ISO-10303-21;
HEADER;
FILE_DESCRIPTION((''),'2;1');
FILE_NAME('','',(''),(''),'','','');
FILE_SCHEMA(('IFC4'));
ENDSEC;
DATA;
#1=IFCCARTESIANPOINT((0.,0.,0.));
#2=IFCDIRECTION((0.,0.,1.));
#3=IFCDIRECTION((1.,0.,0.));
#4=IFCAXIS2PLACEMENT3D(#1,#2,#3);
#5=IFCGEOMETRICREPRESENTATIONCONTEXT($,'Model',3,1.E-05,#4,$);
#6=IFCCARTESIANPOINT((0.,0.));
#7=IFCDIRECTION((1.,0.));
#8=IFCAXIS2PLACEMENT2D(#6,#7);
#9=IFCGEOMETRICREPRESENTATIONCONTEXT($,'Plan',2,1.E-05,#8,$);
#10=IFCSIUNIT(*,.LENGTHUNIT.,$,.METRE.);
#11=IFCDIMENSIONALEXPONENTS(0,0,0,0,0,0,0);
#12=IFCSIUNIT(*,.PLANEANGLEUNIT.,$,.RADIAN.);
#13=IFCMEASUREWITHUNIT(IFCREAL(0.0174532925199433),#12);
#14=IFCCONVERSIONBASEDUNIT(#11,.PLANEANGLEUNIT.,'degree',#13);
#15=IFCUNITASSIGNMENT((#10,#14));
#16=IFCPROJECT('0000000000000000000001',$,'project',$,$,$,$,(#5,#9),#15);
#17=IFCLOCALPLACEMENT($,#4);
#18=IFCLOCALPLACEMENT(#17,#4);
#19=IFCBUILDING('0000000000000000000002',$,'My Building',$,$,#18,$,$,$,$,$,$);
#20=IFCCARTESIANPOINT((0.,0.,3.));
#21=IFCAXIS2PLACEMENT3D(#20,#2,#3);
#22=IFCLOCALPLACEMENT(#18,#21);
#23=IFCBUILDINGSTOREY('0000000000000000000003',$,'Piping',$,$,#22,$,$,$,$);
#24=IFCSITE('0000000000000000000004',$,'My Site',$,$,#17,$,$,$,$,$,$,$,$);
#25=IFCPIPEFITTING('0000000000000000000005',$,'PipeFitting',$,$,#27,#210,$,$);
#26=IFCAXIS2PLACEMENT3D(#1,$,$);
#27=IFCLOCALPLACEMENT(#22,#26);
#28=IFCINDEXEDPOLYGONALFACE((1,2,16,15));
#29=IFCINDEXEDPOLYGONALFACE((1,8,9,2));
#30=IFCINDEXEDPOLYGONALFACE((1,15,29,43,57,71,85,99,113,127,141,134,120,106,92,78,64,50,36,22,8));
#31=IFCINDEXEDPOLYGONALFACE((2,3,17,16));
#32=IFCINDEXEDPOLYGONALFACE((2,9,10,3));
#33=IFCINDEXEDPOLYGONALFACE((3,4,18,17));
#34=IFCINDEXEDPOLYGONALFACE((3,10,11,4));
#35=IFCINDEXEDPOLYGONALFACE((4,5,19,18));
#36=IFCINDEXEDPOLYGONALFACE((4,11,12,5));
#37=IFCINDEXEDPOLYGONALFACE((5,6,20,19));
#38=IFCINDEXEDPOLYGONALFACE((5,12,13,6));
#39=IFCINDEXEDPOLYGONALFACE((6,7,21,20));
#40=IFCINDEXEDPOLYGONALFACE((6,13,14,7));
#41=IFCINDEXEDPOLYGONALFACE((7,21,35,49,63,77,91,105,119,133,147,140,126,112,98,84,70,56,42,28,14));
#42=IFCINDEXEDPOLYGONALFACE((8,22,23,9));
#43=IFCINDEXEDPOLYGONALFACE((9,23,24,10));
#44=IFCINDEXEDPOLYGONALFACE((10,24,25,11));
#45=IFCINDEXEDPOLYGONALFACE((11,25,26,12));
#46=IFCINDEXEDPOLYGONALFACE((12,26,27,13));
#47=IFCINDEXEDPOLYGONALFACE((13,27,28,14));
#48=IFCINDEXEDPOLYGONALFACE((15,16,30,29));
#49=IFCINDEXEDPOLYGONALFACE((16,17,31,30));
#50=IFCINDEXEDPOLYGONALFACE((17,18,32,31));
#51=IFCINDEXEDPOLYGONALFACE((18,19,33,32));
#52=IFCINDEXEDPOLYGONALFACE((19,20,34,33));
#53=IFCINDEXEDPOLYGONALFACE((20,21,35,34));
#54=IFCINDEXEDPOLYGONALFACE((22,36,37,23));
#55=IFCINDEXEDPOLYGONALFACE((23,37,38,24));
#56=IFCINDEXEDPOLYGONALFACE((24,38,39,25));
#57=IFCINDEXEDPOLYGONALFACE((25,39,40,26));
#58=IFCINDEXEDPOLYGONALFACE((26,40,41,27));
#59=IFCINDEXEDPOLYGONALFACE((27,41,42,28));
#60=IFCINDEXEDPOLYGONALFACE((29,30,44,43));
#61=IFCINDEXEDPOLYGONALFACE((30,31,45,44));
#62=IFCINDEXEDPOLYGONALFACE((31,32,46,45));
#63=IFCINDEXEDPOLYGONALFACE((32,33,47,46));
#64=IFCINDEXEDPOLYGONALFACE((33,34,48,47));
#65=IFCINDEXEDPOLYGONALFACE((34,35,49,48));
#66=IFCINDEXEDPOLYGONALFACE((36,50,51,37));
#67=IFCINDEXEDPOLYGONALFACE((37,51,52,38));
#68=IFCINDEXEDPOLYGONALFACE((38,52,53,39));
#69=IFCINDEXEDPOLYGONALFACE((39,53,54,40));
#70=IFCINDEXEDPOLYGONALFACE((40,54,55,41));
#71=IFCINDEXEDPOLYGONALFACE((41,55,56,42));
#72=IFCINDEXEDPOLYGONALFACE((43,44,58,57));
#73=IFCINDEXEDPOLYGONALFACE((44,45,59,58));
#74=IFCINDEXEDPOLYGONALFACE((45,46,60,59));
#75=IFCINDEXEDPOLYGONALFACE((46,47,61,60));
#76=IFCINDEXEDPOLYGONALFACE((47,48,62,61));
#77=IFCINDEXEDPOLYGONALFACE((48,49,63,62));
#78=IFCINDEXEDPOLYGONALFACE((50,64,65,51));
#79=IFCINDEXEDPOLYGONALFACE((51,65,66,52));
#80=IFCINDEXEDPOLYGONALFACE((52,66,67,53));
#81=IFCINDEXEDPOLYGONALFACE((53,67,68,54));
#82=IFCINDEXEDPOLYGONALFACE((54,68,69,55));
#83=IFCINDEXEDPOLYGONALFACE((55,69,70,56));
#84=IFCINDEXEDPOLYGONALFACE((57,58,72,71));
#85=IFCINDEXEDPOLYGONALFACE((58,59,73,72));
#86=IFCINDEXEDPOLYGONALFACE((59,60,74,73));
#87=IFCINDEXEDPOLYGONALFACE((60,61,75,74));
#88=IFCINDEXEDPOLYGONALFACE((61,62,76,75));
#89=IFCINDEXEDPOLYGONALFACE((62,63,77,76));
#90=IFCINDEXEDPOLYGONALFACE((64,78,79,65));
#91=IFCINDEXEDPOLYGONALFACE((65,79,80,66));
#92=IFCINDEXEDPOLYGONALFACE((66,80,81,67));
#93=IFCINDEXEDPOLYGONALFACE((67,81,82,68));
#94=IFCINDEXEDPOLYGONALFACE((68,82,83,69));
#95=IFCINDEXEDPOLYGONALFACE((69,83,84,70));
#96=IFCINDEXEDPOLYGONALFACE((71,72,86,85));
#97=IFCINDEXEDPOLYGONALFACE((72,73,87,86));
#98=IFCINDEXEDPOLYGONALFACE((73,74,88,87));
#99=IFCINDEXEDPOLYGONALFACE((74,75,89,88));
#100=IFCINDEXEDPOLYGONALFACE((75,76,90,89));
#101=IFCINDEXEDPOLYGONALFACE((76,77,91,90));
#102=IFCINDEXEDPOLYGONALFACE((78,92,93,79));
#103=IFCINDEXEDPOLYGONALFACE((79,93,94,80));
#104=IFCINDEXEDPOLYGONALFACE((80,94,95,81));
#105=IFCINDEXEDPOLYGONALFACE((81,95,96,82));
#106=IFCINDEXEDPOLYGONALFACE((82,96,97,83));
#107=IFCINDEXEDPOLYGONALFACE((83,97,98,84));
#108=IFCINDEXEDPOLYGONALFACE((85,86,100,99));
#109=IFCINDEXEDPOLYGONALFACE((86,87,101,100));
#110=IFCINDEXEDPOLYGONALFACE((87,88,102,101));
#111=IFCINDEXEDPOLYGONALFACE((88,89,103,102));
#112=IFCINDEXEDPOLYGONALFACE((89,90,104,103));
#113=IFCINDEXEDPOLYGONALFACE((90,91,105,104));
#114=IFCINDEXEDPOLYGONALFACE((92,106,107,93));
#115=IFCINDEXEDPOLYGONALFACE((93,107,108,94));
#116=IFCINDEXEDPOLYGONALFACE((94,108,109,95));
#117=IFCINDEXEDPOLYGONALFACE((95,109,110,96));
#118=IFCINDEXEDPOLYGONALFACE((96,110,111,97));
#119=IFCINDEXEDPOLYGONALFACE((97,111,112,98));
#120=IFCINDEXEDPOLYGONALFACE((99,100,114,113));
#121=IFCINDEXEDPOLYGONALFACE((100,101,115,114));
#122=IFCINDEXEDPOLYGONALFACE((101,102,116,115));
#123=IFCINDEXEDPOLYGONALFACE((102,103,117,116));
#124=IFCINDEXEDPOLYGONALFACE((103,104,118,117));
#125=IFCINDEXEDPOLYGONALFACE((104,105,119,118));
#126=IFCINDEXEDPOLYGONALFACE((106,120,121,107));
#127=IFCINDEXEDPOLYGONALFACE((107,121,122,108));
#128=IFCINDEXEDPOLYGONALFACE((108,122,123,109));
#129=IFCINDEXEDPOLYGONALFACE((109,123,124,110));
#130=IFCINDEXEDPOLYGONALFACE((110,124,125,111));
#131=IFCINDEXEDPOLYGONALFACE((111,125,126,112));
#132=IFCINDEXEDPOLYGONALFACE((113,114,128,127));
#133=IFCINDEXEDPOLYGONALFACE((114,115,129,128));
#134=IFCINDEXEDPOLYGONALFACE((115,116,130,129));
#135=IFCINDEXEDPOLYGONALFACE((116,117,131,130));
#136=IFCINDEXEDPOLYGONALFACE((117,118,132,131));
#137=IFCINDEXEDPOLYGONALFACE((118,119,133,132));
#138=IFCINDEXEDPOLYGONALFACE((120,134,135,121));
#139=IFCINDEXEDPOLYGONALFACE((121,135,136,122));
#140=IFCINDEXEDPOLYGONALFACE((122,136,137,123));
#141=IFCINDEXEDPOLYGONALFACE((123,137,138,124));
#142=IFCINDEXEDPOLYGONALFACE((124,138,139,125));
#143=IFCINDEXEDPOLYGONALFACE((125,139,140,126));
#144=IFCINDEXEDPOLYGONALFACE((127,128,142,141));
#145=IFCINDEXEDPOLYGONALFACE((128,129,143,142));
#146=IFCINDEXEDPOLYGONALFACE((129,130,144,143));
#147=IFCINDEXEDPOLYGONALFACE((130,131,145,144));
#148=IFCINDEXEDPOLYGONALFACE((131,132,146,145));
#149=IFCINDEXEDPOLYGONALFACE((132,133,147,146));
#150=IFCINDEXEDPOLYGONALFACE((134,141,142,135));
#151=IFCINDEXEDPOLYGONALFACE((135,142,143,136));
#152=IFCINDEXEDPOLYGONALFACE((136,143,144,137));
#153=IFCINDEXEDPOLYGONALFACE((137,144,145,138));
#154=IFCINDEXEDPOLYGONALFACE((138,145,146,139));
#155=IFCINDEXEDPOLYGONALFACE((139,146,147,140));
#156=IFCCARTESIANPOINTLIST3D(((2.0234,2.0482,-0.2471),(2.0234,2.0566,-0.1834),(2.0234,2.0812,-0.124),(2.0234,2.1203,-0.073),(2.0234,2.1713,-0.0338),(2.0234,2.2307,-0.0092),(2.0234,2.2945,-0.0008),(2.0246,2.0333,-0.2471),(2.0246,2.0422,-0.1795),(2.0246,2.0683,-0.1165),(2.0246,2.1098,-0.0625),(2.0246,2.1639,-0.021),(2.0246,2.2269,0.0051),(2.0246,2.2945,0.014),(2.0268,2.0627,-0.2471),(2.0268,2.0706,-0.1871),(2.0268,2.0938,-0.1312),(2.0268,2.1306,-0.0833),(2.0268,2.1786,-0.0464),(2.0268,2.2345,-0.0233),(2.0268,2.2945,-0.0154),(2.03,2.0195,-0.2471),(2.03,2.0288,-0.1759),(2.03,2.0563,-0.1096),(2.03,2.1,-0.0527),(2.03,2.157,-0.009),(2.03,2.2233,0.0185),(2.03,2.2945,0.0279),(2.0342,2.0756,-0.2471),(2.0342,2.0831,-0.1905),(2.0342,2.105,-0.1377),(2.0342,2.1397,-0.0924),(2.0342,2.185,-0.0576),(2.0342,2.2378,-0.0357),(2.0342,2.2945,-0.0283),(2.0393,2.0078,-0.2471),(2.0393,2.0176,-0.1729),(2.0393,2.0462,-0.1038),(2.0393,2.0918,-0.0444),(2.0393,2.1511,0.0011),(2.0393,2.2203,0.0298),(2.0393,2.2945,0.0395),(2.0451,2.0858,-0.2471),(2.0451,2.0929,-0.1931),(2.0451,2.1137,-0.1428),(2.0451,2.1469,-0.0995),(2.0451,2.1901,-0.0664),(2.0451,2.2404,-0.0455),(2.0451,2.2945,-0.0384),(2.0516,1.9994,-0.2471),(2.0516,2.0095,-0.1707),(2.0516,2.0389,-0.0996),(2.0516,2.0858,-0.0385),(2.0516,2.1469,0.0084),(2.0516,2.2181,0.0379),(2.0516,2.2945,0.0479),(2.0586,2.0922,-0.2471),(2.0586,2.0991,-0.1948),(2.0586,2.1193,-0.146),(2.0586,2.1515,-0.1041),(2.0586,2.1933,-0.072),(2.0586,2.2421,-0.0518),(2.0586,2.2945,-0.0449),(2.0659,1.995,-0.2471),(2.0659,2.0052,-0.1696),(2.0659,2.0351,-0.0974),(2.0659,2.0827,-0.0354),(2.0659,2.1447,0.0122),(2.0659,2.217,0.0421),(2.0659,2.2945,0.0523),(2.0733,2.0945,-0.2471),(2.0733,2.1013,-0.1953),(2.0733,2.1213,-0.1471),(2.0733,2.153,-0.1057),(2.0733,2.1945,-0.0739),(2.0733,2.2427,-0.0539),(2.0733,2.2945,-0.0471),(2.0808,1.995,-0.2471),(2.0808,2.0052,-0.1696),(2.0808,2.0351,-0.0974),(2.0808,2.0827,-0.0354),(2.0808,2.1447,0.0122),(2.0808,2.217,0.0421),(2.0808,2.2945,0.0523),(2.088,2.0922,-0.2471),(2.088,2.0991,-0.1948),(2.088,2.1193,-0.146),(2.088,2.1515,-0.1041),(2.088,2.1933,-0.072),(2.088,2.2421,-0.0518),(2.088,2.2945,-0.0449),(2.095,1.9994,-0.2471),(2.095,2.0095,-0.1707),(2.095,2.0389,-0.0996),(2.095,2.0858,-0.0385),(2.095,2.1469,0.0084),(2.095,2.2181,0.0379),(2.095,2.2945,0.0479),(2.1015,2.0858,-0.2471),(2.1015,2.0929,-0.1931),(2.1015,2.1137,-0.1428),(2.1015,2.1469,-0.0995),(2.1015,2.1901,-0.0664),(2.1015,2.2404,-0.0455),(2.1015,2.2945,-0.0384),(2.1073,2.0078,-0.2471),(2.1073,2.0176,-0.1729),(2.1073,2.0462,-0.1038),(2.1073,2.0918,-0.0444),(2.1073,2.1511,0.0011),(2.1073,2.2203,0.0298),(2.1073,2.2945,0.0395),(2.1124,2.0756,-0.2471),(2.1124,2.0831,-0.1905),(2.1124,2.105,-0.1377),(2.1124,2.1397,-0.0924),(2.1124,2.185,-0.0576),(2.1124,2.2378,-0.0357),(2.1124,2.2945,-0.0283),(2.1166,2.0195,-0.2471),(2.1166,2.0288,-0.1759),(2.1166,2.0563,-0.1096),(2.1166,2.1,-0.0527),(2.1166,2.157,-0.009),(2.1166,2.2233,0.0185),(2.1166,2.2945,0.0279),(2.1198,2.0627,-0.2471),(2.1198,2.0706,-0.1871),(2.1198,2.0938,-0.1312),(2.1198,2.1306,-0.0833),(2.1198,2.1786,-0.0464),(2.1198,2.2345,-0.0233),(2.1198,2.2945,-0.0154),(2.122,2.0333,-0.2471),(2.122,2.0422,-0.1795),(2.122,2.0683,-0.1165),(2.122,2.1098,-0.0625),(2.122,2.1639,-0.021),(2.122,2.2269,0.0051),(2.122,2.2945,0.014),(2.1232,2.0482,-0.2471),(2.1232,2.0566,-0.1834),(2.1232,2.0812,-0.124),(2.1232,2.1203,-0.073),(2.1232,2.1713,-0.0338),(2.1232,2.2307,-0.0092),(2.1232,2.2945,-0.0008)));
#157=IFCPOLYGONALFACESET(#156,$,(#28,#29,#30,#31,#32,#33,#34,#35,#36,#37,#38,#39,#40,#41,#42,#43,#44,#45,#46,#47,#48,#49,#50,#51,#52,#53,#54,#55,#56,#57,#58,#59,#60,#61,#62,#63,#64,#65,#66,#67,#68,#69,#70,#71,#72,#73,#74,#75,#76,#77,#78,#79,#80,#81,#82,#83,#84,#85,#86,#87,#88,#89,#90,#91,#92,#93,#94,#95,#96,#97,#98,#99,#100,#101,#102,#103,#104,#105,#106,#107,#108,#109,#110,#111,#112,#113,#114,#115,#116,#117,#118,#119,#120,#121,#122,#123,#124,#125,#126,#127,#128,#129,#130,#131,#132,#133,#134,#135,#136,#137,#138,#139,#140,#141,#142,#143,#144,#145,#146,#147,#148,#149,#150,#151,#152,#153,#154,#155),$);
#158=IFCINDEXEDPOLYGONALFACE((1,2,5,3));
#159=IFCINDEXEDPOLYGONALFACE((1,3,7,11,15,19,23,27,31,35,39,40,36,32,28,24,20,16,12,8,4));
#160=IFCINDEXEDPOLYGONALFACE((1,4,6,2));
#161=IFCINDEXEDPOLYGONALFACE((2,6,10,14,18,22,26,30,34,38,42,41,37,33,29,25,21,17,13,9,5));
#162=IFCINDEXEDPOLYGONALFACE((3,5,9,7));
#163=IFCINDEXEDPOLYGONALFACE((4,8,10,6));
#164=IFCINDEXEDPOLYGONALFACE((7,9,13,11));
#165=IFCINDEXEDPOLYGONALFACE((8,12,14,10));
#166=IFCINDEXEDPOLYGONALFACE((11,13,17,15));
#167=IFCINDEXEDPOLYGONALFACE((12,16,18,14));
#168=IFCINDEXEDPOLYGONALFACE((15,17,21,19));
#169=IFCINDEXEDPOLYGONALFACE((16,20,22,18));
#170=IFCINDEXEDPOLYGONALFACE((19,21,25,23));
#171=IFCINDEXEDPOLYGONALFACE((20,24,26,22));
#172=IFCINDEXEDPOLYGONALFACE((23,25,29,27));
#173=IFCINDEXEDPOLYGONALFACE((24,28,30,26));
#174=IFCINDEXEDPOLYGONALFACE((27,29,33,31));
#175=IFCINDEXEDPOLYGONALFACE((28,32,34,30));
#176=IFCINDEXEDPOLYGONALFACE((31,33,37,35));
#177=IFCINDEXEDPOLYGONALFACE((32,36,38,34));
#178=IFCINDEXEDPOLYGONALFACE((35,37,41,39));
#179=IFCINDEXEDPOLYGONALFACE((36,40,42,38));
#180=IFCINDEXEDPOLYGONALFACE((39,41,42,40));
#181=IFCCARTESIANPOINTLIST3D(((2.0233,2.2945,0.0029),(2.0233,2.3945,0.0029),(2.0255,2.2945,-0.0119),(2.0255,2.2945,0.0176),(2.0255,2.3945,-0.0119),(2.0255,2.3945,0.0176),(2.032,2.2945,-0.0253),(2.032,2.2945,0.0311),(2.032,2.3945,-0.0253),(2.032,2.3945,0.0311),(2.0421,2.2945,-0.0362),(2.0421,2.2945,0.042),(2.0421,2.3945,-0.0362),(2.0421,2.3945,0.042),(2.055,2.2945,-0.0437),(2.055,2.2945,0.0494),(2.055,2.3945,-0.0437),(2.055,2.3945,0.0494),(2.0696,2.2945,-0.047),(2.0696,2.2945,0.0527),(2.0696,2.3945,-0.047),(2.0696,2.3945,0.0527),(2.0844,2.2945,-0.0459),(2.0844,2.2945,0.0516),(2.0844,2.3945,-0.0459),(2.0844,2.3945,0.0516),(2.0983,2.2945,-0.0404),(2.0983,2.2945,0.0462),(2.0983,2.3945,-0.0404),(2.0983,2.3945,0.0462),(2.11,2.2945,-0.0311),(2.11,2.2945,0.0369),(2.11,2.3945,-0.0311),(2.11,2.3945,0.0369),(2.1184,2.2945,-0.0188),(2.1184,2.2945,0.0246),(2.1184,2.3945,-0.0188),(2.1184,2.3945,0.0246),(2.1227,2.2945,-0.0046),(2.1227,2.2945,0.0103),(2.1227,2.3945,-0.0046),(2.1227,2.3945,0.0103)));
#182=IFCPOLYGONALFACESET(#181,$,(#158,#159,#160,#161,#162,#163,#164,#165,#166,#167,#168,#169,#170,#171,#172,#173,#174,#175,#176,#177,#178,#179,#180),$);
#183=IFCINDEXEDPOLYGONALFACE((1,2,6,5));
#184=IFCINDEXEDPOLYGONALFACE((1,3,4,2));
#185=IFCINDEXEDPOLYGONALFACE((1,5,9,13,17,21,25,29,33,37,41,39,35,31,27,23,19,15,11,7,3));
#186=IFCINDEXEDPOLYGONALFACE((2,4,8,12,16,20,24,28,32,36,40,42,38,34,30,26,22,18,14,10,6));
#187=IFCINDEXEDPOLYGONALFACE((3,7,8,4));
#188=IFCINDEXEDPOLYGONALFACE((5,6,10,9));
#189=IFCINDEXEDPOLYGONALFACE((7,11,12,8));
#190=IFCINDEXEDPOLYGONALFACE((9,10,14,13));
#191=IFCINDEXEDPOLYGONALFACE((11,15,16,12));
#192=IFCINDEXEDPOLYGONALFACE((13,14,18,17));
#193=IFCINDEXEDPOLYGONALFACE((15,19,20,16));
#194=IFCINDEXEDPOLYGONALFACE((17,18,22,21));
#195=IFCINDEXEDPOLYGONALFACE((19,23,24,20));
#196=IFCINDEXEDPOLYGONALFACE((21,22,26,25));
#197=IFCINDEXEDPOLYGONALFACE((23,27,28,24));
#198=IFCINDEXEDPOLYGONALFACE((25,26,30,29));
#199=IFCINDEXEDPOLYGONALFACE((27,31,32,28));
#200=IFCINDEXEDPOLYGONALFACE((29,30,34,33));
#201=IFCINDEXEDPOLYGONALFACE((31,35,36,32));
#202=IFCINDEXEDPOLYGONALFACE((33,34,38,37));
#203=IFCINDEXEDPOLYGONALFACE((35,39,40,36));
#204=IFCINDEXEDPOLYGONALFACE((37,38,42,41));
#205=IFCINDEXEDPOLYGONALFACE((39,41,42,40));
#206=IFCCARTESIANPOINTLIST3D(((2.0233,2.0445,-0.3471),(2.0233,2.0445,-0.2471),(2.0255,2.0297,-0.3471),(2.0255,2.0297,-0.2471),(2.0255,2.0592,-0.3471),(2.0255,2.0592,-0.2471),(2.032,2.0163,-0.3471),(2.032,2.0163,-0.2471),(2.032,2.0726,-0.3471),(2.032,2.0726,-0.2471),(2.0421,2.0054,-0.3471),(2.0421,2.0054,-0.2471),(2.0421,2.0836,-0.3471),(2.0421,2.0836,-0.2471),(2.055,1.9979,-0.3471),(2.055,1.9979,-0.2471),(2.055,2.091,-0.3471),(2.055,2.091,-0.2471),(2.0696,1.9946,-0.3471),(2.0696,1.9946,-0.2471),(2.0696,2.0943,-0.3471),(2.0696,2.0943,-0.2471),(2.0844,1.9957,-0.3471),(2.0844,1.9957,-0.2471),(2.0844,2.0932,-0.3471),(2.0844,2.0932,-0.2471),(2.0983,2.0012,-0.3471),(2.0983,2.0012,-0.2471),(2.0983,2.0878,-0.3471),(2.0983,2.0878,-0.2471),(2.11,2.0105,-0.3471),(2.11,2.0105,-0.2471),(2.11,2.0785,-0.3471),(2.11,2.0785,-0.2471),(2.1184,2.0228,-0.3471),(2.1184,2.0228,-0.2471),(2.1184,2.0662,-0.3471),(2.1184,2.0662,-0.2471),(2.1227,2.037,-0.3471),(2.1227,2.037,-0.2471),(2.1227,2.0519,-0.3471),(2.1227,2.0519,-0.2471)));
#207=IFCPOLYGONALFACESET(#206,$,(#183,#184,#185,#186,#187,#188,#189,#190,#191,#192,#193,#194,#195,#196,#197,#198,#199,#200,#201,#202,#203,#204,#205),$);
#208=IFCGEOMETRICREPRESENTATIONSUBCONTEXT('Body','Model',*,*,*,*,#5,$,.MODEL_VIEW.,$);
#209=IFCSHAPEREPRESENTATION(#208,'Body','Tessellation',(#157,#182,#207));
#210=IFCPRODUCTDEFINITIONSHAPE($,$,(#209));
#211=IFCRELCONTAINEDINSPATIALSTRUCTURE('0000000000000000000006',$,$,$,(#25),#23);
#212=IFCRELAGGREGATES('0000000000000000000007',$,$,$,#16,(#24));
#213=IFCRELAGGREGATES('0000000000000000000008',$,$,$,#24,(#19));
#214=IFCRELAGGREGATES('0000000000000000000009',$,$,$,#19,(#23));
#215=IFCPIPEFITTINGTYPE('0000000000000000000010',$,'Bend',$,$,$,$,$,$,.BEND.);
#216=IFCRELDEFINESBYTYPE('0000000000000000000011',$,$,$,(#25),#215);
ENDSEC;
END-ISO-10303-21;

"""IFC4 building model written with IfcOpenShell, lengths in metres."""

from ifc_helpers import new_model, entity, si_unit, converted_unit, frame, origin_with_axes, origin_2d_with_axis, place, context, subcontext, project, spatial, circle, extrude, source, transform, mapped, type_object, type_shapes, element, save


model = new_model("IFC4")

# Units and contexts
model_context = context("Model", 3, precision=1e-05, world=origin_with_axes())
plan_context = context("Plan", 2, precision=1e-05, world=origin_2d_with_axis())
body_context = subcontext(model_context, "Body", "Model", "MODEL_VIEW")
ifc_project = project(units=[si_unit("LENGTHUNIT", "METRE"), converted_unit("PLANEANGLEUNIT", "degree", entity("IfcReal", 0.0174532925199433), si_unit("PLANEANGLEUNIT", "RADIAN"), dimensions=[0, 0, 0, 0, 0, 0, 0])], contexts=[model_context, plan_context])

# Site, building, storey
site_placement = place(None, origin_with_axes())
site = spatial("IfcSite", under=ifc_project, at=site_placement, Name="My Site")
building_placement = place(site_placement, origin_with_axes())
building = spatial("IfcBuilding", under=site, at=building_placement, Name="My Building")
storey_placement = place(building_placement, frame((0.0, 0.0, 3.0), z_axis=(0.0, 0.0, 1.0), x_axis=(1.0, 0.0, 0.0)))
storey = spatial("IfcBuildingStorey", under=building, at=storey_placement, Name="Piping")

# Pipe fitting
pipe_fitting_type_1 = type_object("IfcPipeFittingType", Name="Bend", PredefinedType="BEND")
shared_shape = source(origin_with_axes(), body_context, "Body", "SolidModel", [
    entity("IfcSweptDiskSolid", entity("IfcIndexedPolyCurve", entity("IfcCartesianPointList3D", [[0.0, 0.0, -0.1], [0.0, -0.0732, -0.2768], [0.0, -0.25, -0.35]]), [entity("IfcArcIndex", [1, 2, 3])]), 0.05),
    extrude(circle(Radius=0.05), origin_with_axes(), (0.0, 0.0, -1.0), 0.1),
    extrude(circle(Radius=0.05), frame((0.0, -0.25, -0.35), z_axis=(0.0, -1.0, 0.0), x_axis=(1.0, 0.0, 0.0)), (0.0, 0.0, 1.0), 0.1),
])
type_shapes(pipe_fitting_type_1, [shared_shape])
for number, where, z_axis, x_axis, name in (
    (1, (2.0733, 2.3945, 0.0029), (0.0, 1.0, 0.0), (-1.0, 0.0, 0.0), "PipeFitting"),
):
    element("IfcPipeFitting", number, at=place(storey_placement, frame(where, z_axis=z_axis, x_axis=x_axis)), inside=storey, type_object=pipe_fitting_type_1, Name=name, context=body_context, shape_type="MappedRepresentation", body=[
        mapped(shared_shape, transform((0.0, 0.0, 0.0), x_axis=(1.0, 0.0, 0.0), y_axis=(0.0, 1.0, 0.0), z_axis=(0.0, 0.0, 1.0), scale=1.0)),
    ])

save(model, "model.ifc")
